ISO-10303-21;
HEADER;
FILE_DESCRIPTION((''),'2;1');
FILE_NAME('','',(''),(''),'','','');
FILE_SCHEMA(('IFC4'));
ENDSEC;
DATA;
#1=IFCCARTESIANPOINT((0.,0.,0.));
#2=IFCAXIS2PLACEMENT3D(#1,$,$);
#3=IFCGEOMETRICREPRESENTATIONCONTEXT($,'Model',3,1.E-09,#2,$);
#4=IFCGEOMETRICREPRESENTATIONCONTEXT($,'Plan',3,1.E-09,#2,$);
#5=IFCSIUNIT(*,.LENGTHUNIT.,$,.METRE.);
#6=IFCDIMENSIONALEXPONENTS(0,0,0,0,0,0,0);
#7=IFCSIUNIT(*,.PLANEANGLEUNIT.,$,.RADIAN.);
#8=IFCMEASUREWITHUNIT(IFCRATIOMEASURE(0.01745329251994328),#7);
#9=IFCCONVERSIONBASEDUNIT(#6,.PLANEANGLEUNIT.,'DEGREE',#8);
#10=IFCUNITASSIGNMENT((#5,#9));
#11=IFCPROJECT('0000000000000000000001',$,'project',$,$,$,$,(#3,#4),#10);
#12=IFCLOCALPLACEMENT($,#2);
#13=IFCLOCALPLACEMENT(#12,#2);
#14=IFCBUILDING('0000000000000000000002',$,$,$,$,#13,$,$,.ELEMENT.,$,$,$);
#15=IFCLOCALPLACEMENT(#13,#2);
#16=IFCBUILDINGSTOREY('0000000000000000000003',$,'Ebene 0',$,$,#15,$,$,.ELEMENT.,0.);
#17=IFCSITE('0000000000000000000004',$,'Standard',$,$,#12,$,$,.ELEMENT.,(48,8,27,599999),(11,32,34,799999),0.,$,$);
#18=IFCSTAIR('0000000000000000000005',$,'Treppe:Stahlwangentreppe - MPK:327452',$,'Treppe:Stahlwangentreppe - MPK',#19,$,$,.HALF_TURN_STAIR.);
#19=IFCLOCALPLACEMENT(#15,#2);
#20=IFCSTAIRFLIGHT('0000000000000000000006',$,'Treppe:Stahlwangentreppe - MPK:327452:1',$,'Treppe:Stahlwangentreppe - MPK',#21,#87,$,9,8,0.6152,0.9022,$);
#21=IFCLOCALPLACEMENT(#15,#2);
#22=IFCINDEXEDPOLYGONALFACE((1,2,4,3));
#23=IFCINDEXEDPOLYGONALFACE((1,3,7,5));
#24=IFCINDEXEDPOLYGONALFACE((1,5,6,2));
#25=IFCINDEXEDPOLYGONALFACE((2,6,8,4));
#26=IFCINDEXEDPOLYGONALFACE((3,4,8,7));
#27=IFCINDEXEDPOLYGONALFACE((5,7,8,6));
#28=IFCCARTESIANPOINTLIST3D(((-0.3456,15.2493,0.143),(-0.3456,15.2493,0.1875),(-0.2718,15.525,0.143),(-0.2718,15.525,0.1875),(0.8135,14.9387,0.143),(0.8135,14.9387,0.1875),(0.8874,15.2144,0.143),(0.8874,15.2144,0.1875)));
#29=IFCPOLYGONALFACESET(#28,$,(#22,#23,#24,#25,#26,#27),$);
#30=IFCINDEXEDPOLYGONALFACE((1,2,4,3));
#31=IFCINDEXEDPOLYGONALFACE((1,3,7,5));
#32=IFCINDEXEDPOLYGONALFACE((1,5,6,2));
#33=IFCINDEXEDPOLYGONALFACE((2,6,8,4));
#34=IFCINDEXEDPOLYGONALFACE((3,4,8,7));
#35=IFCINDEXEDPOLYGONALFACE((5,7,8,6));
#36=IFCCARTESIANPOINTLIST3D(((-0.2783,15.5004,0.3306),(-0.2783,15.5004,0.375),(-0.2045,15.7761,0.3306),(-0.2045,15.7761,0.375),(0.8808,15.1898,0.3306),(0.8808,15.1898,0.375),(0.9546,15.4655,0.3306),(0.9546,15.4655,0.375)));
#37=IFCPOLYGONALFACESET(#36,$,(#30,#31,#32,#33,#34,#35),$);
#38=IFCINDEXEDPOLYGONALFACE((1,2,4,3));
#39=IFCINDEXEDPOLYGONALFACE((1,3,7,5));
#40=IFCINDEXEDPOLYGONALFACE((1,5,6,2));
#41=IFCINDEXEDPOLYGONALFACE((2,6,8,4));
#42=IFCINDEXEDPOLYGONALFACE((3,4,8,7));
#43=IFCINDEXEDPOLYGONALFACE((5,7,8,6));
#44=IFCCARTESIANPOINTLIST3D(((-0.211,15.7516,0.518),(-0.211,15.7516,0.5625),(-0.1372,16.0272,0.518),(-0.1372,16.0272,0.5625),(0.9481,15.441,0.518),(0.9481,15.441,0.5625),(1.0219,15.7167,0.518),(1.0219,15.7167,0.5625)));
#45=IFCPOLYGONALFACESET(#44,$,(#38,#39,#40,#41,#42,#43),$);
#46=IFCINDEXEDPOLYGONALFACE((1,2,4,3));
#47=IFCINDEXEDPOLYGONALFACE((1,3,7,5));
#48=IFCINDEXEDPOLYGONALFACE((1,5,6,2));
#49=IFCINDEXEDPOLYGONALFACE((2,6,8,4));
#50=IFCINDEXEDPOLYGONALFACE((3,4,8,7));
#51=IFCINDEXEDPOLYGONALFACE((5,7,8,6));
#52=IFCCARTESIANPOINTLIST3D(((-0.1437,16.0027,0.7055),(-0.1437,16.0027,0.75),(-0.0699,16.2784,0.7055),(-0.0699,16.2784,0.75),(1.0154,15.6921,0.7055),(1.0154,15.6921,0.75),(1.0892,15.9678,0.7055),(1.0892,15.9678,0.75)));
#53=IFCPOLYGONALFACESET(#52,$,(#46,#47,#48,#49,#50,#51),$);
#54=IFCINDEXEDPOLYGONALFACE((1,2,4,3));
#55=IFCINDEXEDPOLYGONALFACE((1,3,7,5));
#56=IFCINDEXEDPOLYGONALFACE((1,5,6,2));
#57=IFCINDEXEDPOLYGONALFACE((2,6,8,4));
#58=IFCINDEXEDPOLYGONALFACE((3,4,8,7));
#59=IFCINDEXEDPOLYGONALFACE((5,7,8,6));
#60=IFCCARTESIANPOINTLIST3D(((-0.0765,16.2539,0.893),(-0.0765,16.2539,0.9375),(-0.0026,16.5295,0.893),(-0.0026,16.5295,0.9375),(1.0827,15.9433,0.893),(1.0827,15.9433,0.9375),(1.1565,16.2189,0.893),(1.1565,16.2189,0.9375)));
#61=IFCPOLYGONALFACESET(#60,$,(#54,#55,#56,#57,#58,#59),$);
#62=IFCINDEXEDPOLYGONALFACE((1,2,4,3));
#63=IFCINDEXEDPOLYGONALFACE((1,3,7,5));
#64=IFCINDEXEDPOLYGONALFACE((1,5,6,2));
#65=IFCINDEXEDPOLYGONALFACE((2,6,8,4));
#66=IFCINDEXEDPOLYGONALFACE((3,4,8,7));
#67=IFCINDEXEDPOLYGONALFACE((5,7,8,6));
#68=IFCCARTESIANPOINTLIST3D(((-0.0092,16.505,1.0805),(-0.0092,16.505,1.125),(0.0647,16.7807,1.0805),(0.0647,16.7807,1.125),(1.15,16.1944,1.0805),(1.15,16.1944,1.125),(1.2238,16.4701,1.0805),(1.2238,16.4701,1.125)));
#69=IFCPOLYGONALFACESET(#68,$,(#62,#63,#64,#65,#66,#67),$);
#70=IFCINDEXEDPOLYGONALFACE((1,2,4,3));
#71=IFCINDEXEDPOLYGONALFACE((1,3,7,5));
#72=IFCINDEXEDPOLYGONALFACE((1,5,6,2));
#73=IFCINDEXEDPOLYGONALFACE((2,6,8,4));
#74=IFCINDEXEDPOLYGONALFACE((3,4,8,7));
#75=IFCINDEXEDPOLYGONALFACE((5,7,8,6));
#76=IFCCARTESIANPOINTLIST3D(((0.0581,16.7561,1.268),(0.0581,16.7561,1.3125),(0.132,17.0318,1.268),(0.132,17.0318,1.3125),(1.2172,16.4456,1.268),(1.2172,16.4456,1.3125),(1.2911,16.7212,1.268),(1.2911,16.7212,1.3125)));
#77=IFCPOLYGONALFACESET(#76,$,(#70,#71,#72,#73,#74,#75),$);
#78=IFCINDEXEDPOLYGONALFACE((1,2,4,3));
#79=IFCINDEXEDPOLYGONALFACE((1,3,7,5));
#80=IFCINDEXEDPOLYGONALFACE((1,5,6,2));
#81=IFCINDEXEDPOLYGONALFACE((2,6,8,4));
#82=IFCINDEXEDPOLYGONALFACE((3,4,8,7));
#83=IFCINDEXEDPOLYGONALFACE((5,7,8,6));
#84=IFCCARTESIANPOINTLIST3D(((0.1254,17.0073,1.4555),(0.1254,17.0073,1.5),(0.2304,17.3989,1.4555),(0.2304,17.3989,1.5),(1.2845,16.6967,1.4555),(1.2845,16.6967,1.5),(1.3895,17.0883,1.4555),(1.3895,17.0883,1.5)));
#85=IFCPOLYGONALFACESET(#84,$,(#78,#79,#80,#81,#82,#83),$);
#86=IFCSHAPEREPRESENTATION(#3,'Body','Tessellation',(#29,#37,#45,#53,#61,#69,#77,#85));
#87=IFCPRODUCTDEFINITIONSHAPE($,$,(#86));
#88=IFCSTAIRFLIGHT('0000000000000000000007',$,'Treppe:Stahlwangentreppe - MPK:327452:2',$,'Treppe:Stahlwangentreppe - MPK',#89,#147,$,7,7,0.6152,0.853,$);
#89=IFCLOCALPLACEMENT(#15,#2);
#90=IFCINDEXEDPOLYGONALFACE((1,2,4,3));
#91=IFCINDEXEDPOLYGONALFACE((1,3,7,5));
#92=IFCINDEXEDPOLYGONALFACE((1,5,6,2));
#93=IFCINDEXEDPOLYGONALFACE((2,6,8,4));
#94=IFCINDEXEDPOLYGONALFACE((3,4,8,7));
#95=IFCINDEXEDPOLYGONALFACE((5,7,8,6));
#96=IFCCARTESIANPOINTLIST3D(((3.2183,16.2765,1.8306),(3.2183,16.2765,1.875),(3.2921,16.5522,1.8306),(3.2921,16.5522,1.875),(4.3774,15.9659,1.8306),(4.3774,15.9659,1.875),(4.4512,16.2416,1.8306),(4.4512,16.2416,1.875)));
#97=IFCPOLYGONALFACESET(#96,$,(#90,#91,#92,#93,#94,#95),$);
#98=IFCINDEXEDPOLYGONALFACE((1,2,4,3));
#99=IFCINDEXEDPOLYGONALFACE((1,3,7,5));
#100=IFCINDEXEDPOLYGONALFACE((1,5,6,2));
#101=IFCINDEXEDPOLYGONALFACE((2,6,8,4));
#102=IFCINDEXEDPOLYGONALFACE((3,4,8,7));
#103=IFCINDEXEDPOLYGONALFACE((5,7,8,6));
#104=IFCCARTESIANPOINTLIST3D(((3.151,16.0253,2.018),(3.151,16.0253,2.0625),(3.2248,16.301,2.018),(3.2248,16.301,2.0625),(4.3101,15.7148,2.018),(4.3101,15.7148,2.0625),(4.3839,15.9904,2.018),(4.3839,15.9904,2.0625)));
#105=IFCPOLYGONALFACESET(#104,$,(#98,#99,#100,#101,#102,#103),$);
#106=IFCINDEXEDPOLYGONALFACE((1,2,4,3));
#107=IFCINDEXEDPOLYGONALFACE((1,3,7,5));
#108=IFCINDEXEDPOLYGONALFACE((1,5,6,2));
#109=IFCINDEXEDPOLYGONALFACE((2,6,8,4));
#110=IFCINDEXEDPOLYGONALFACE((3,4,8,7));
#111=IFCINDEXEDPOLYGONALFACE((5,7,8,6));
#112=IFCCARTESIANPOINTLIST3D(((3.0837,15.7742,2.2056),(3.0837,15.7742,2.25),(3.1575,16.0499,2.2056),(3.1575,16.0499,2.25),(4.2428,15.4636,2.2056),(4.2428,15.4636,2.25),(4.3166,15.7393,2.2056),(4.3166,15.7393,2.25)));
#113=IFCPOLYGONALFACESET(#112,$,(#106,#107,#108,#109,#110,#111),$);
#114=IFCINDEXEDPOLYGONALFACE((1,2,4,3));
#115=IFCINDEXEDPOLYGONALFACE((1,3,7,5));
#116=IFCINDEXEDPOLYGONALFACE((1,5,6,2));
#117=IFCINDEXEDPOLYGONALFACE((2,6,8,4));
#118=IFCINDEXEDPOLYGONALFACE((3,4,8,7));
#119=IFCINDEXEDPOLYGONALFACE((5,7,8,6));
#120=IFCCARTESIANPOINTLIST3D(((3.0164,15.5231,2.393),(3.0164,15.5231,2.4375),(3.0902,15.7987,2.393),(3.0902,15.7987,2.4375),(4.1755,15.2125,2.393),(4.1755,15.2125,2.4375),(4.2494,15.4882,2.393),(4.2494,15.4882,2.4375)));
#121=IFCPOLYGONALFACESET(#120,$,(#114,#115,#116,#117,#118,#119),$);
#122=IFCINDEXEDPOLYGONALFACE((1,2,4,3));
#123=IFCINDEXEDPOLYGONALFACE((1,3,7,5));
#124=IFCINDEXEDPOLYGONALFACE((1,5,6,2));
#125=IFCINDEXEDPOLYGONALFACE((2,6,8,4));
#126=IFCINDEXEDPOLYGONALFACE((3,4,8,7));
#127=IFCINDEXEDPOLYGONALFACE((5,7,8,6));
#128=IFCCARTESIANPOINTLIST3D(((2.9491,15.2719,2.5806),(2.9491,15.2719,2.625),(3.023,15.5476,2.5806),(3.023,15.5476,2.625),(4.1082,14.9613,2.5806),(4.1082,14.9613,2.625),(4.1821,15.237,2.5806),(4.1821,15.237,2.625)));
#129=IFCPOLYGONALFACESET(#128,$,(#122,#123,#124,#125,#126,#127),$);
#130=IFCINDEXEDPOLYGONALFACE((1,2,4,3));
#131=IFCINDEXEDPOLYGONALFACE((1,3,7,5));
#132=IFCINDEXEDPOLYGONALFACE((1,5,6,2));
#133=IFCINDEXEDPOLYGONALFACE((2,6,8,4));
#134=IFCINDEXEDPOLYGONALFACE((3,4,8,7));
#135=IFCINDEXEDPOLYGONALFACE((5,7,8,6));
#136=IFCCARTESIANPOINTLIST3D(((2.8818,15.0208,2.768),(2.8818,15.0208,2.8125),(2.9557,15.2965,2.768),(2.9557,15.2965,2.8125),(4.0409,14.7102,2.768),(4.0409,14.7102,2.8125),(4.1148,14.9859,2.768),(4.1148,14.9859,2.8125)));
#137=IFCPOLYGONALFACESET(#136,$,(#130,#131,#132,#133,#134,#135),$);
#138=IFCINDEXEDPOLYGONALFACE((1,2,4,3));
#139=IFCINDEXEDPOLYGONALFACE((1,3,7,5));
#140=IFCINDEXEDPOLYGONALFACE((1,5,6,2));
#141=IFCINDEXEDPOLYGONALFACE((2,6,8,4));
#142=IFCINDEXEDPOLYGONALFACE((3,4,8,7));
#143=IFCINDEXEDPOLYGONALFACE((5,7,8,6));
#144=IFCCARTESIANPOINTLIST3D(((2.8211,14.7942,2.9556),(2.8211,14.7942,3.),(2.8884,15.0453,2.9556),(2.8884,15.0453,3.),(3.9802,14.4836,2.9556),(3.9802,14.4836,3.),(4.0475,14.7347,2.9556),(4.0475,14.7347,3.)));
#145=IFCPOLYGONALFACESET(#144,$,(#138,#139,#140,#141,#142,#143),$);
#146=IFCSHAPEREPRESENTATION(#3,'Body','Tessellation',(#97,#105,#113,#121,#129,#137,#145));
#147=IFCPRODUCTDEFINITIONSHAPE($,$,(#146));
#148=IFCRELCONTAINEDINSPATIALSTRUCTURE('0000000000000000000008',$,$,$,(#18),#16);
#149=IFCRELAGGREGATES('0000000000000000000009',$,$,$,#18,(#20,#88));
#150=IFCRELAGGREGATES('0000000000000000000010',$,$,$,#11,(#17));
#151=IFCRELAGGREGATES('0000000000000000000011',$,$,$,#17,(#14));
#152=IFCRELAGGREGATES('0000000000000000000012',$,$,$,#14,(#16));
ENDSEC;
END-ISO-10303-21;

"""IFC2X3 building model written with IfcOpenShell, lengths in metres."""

from ifc_helpers import new_model, entity, si_unit, converted_unit, frame, frame_2d, origin, origin_2d_with_axis, place, context, project, spatial, rectangle, extrude, element, aggregate, save


model = new_model("IFC2X3")

# Units and contexts
model_context = context("Model", 3, precision=1e-09, world=origin())
plan_context = context("Plan", 3, precision=1e-09, world=origin())
ifc_project = project(units=[si_unit("LENGTHUNIT", "METRE"), converted_unit("PLANEANGLEUNIT", "DEGREE", entity("IfcRatioMeasure", 0.01745329251994328), si_unit("PLANEANGLEUNIT", "RADIAN"), dimensions=[0, 0, 0, 0, 0, 0, 0])], contexts=[model_context, plan_context])

# Site, building, storey
site_placement = place(None, origin())
site = spatial("IfcSite", under=ifc_project, at=site_placement, Name="Standard", CompositionType="ELEMENT", RefLatitude=(48, 8, 27, 599999), RefLongitude=(11, 32, 34, 799999), RefElevation=0.0)
building_placement = place(site_placement, origin())
building = spatial("IfcBuilding", under=site, at=building_placement, CompositionType="ELEMENT")
storey_placement = place(building_placement, origin())
storey = spatial("IfcBuildingStorey", under=building, at=storey_placement, Name="Ebene 0", CompositionType="ELEMENT", Elevation=0.0)

# Stair
stair_placement = place(storey_placement, origin())
stair = element("IfcStair", 1, at=stair_placement, inside=storey, Name="Treppe:Stahlwangentreppe - MPK:327452", ObjectType="Treppe:Stahlwangentreppe - MPK", ShapeType="HALF_TURN_STAIR")

# Stair flights
stair_flight_1_placement = place(storey_placement, origin())
stair_flight_1 = element("IfcStairFlight", 2, at=stair_flight_1_placement, Name="Treppe:Stahlwangentreppe - MPK:327452:1", ObjectType="Treppe:Stahlwangentreppe - MPK", NumberOfRiser=9, NumberOfTreads=8, RiserHeight=0.6152, TreadLength=0.9022, context=model_context, shape_type="SweptSolid", body=[
    extrude(rectangle(XDim=0.2854, YDim=1.2, at=origin_2d_with_axis()), frame((0.2709, 15.2318, 0.1431), z_axis=(0.0, 0.0, 1.0), x_axis=(-0.258819, -0.965926, 0.0)), (0.0, 0.0, 1.0), 0.0445),
    extrude(rectangle(XDim=0.2854, YDim=1.2, at=origin_2d_with_axis()), frame((0.3382, 15.483, 0.3306), z_axis=(0.0, 0.0, 1.0), x_axis=(-0.258819, -0.965926, 0.0)), (0.0, 0.0, 1.0), 0.0445),
    extrude(rectangle(XDim=0.2854, YDim=1.2, at=origin_2d_with_axis()), frame((0.4055, 15.7341, 0.518), z_axis=(0.0, 0.0, 1.0), x_axis=(-0.258819, -0.965926, 0.0)), (0.0, 0.0, 1.0), 0.0445),
    extrude(rectangle(XDim=0.2854, YDim=1.2, at=origin_2d_with_axis()), frame((0.4727, 15.9853, 0.7055), z_axis=(0.0, 0.0, 1.0), x_axis=(-0.258819, -0.965926, 0.0)), (0.0, 0.0, 1.0), 0.0445),
    extrude(rectangle(XDim=0.2854, YDim=1.2, at=origin_2d_with_axis()), frame((0.54, 16.2364, 0.893), z_axis=(0.0, 0.0, 1.0), x_axis=(-0.258819, -0.965926, 0.0)), (0.0, 0.0, 1.0), 0.0445),
    extrude(rectangle(XDim=0.2854, YDim=1.2, at=origin_2d_with_axis()), frame((0.6073, 16.4875, 1.0805), z_axis=(0.0, 0.0, 1.0), x_axis=(-0.258819, -0.965926, 0.0)), (0.0, 0.0, 1.0), 0.0445),
    extrude(rectangle(XDim=0.2854, YDim=1.2, at=origin_2d_with_axis()), frame((0.6746, 16.7387, 1.268), z_axis=(0.0, 0.0, 1.0), x_axis=(-0.258819, -0.965926, 0.0)), (0.0, 0.0, 1.0), 0.0444),
    extrude(rectangle(XDim=0.4054, YDim=1.2, at=frame_2d((0.0355, 0.12), x_axis=(1.0, 0.0))), frame((0.6507, 17.1131, 1.4555), z_axis=(0.0, 0.0, 1.0), x_axis=(-0.258819, -0.965926, 0.0)), (0.0, 0.0, 1.0), 0.0444),
])
stair_flight_2_placement = place(storey_placement, origin())
stair_flight_2 = element("IfcStairFlight", 3, at=stair_flight_2_placement, Name="Treppe:Stahlwangentreppe - MPK:327452:2", ObjectType="Treppe:Stahlwangentreppe - MPK", NumberOfRiser=7, NumberOfTreads=7, RiserHeight=0.6152, TreadLength=0.853, context=model_context, shape_type="SweptSolid", body=[
    extrude(rectangle(XDim=0.2854, YDim=1.2, at=origin_2d_with_axis()), frame((3.8347, 16.259, 1.8305), z_axis=(0.0, 0.0, 1.0), x_axis=(0.258819, 0.965926, 0.0)), (0.0, 0.0, 1.0), 0.0444),
    extrude(rectangle(XDim=0.2854, YDim=1.2, at=origin_2d_with_axis()), frame((3.7675, 16.0079, 2.0181), z_axis=(0.0, 0.0, 1.0), x_axis=(0.258819, 0.965926, 0.0)), (0.0, 0.0, 1.0), 0.0444),
    extrude(rectangle(XDim=0.2854, YDim=1.2, at=origin_2d_with_axis()), frame((3.7002, 15.7568, 2.2056), z_axis=(0.0, 0.0, 1.0), x_axis=(0.258819, 0.965926, 0.0)), (0.0, 0.0, 1.0), 0.0444),
    extrude(rectangle(XDim=0.2854, YDim=1.2, at=origin_2d_with_axis()), frame((3.6329, 15.5056, 2.3931), z_axis=(0.0, 0.0, 1.0), x_axis=(0.258819, 0.965926, 0.0)), (0.0, 0.0, 1.0), 0.0444),
    extrude(rectangle(XDim=0.2854, YDim=1.2, at=origin_2d_with_axis()), frame((3.5656, 15.2545, 2.5806), z_axis=(0.0, 0.0, 1.0), x_axis=(0.258819, 0.965926, 0.0)), (0.0, 0.0, 1.0), 0.0445),
    extrude(rectangle(XDim=0.2854, YDim=1.2, at=origin_2d_with_axis()), frame((3.4983, 15.0033, 2.768), z_axis=(0.0, 0.0, 1.0), x_axis=(0.258819, 0.965926, 0.0)), (0.0, 0.0, 1.0), 0.0445),
    extrude(rectangle(XDim=0.26, YDim=1.2, at=origin_2d_with_axis()), frame((3.4343, 14.7645, 2.9556), z_axis=(0.0, 0.0, 1.0), x_axis=(0.258819, 0.965926, 0.0)), (0.0, 0.0, 1.0), 0.0445),
])
aggregate(stair, [stair_flight_1, stair_flight_2])

save(model, "model.ifc")
